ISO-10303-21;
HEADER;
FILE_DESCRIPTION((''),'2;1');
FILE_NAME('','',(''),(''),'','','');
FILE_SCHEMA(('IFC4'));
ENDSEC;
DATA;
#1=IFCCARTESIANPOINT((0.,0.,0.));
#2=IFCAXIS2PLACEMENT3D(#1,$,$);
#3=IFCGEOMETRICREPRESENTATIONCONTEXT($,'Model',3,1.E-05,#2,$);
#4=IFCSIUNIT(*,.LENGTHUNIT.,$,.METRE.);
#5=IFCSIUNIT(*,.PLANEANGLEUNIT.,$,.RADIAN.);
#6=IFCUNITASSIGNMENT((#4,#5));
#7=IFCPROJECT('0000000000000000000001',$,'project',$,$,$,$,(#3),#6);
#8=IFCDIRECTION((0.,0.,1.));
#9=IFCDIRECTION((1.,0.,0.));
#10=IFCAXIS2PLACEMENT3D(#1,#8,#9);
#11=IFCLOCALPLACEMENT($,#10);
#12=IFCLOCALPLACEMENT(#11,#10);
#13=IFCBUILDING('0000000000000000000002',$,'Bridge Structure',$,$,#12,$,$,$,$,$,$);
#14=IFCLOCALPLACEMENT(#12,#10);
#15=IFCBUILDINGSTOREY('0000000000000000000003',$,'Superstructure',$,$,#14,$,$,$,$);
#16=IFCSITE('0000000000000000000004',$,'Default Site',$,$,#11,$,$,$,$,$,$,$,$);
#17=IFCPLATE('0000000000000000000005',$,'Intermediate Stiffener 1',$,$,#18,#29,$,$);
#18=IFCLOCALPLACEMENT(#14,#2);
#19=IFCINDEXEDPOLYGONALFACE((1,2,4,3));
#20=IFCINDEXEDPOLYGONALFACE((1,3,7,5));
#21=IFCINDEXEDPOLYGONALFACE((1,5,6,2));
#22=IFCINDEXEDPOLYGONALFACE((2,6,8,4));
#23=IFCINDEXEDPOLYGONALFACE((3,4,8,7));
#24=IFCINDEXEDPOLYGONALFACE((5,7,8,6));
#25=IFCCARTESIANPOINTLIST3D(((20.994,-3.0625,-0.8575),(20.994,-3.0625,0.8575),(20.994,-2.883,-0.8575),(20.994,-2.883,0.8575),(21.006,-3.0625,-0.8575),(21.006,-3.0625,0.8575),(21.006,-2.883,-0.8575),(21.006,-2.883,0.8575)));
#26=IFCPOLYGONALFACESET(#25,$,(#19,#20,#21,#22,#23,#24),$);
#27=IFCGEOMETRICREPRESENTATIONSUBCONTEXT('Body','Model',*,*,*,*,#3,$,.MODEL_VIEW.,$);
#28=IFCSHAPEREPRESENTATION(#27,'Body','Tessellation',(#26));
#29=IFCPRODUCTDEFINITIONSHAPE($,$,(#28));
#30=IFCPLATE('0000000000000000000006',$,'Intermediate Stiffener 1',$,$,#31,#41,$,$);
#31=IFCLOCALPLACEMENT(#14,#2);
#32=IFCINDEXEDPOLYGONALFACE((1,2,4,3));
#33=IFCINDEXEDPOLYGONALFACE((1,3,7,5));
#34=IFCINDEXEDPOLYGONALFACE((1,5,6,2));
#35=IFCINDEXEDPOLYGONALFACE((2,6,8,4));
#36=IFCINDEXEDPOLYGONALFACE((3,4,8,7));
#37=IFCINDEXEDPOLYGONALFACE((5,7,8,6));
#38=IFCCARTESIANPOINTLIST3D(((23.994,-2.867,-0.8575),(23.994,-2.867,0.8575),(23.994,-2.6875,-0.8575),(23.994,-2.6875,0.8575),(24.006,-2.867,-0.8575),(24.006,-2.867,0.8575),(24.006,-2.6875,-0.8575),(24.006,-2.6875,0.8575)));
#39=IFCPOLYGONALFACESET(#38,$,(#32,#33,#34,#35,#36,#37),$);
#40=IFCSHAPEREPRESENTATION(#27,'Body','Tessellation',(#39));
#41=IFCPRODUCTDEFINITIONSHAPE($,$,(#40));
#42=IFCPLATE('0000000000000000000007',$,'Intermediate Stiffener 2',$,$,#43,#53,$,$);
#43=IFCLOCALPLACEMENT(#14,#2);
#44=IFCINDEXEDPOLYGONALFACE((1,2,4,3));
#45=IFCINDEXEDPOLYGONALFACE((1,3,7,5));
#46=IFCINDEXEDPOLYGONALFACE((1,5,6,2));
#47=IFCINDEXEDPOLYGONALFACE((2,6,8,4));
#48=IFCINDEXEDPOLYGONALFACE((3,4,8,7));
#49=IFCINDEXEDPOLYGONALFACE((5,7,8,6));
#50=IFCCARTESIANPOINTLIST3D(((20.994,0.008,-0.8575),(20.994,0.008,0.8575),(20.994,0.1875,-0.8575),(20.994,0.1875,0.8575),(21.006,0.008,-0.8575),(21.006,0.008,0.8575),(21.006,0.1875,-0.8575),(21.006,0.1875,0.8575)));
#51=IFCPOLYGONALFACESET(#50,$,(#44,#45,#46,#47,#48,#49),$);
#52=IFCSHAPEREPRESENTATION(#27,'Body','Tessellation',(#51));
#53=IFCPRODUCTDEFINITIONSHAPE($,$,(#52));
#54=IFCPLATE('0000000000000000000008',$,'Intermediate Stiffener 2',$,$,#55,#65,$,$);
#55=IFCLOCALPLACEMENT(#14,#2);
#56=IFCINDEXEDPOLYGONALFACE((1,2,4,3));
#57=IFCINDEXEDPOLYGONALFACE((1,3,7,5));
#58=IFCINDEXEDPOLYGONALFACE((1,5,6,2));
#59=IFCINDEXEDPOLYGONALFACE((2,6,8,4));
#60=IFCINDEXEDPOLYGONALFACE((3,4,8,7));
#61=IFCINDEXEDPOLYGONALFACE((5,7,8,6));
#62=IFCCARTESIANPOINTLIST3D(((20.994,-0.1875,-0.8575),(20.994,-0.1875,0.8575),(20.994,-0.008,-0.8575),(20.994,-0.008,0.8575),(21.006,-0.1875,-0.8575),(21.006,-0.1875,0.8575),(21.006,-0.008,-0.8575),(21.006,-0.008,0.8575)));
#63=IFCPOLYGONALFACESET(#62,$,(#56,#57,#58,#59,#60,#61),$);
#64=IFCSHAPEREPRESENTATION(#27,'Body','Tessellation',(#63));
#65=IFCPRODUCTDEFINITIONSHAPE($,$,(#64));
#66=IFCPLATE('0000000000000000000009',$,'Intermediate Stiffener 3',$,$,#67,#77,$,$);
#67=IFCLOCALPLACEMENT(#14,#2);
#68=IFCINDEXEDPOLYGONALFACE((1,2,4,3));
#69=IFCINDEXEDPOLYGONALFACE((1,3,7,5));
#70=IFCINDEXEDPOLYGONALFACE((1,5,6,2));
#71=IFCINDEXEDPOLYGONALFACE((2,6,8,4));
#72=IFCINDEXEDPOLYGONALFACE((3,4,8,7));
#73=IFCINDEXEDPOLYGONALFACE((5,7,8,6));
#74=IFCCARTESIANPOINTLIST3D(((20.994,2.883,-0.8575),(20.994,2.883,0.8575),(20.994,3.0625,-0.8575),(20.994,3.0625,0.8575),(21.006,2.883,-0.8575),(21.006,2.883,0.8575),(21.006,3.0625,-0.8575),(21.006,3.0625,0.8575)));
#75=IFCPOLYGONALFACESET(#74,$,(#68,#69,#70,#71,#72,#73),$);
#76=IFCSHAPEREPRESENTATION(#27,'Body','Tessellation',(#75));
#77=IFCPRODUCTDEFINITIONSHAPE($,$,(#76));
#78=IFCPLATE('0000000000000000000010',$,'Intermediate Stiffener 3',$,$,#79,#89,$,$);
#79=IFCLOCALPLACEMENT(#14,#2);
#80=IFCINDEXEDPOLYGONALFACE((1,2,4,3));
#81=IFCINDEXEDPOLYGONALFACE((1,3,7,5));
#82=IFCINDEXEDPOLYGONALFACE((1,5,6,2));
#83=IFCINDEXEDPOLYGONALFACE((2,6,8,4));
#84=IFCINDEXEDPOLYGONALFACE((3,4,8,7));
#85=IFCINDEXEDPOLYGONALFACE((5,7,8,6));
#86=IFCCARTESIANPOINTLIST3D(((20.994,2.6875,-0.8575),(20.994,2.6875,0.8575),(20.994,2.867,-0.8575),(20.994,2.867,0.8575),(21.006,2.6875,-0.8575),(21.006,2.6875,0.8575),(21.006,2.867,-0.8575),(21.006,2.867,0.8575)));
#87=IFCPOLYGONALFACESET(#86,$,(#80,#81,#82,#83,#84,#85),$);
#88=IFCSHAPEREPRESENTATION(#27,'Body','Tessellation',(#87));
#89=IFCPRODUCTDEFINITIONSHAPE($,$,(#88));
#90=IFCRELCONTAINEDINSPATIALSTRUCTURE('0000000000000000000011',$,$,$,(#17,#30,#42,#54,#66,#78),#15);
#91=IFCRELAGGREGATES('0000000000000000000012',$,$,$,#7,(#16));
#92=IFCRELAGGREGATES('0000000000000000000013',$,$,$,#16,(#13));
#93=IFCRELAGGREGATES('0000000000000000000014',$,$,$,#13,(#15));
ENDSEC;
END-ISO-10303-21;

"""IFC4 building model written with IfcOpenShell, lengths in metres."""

from ifc_helpers import new_model, si_unit, frame, origin, origin_with_axes, origin_2d_with_axis, place, context, subcontext, project, spatial, rectangle, extrude, element, save


model = new_model("IFC4")

# Units and contexts
model_context = context("Model", 3, precision=1e-05, world=origin())
body_context = subcontext(model_context, "Body", "Model", "MODEL_VIEW")
ifc_project = project(units=[si_unit("LENGTHUNIT", "METRE"), si_unit("PLANEANGLEUNIT", "RADIAN")], contexts=[model_context])

# Site, building, storey
site_placement = place(None, origin_with_axes())
site = spatial("IfcSite", under=ifc_project, at=site_placement, Name="Default Site")
building_placement = place(site_placement, origin_with_axes())
building = spatial("IfcBuilding", under=site, at=building_placement, Name="Bridge Structure")
storey_placement = place(building_placement, origin_with_axes())
storey = spatial("IfcBuildingStorey", under=building, at=storey_placement, Name="Superstructure")

# Plates
for number, where, z_axis, x_axis, name in (
    (1, (21.0, -2.9728, -0.8575), (0.0, 0.0, 1.0), (1.0, 0.0, 0.0), "Intermediate Stiffener 1"),
    (2, (24.0, -2.7772, -0.8575), (0.0, 0.0, 1.0), (1.0, 0.0, 0.0), "Intermediate Stiffener 1"),
    (3, (21.0, 0.0978, -0.8575), (0.0, 0.0, 1.0), (1.0, 0.0, 0.0), "Intermediate Stiffener 2"),
    (4, (21.0, -0.0978, -0.8575), (0.0, 0.0, 1.0), (1.0, 0.0, 0.0), "Intermediate Stiffener 2"),
    (5, (21.0, 2.9728, -0.8575), (0.0, 0.0, 1.0), (1.0, 0.0, 0.0), "Intermediate Stiffener 3"),
    (6, (21.0, 2.7772, -0.8575), (0.0, 0.0, 1.0), (1.0, 0.0, 0.0), "Intermediate Stiffener 3"),
):
    element("IfcPlate", number, at=place(storey_placement, frame(where, z_axis=z_axis, x_axis=x_axis)), inside=storey, Name=name, context=body_context, shape_type="SweptSolid", body=[
        extrude(rectangle(XDim=0.012, YDim=0.1795, at=origin_2d_with_axis()), origin_with_axes(), (0.0, 0.0, 1.0), 1.715),
    ])

save(model, "model.ifc")
